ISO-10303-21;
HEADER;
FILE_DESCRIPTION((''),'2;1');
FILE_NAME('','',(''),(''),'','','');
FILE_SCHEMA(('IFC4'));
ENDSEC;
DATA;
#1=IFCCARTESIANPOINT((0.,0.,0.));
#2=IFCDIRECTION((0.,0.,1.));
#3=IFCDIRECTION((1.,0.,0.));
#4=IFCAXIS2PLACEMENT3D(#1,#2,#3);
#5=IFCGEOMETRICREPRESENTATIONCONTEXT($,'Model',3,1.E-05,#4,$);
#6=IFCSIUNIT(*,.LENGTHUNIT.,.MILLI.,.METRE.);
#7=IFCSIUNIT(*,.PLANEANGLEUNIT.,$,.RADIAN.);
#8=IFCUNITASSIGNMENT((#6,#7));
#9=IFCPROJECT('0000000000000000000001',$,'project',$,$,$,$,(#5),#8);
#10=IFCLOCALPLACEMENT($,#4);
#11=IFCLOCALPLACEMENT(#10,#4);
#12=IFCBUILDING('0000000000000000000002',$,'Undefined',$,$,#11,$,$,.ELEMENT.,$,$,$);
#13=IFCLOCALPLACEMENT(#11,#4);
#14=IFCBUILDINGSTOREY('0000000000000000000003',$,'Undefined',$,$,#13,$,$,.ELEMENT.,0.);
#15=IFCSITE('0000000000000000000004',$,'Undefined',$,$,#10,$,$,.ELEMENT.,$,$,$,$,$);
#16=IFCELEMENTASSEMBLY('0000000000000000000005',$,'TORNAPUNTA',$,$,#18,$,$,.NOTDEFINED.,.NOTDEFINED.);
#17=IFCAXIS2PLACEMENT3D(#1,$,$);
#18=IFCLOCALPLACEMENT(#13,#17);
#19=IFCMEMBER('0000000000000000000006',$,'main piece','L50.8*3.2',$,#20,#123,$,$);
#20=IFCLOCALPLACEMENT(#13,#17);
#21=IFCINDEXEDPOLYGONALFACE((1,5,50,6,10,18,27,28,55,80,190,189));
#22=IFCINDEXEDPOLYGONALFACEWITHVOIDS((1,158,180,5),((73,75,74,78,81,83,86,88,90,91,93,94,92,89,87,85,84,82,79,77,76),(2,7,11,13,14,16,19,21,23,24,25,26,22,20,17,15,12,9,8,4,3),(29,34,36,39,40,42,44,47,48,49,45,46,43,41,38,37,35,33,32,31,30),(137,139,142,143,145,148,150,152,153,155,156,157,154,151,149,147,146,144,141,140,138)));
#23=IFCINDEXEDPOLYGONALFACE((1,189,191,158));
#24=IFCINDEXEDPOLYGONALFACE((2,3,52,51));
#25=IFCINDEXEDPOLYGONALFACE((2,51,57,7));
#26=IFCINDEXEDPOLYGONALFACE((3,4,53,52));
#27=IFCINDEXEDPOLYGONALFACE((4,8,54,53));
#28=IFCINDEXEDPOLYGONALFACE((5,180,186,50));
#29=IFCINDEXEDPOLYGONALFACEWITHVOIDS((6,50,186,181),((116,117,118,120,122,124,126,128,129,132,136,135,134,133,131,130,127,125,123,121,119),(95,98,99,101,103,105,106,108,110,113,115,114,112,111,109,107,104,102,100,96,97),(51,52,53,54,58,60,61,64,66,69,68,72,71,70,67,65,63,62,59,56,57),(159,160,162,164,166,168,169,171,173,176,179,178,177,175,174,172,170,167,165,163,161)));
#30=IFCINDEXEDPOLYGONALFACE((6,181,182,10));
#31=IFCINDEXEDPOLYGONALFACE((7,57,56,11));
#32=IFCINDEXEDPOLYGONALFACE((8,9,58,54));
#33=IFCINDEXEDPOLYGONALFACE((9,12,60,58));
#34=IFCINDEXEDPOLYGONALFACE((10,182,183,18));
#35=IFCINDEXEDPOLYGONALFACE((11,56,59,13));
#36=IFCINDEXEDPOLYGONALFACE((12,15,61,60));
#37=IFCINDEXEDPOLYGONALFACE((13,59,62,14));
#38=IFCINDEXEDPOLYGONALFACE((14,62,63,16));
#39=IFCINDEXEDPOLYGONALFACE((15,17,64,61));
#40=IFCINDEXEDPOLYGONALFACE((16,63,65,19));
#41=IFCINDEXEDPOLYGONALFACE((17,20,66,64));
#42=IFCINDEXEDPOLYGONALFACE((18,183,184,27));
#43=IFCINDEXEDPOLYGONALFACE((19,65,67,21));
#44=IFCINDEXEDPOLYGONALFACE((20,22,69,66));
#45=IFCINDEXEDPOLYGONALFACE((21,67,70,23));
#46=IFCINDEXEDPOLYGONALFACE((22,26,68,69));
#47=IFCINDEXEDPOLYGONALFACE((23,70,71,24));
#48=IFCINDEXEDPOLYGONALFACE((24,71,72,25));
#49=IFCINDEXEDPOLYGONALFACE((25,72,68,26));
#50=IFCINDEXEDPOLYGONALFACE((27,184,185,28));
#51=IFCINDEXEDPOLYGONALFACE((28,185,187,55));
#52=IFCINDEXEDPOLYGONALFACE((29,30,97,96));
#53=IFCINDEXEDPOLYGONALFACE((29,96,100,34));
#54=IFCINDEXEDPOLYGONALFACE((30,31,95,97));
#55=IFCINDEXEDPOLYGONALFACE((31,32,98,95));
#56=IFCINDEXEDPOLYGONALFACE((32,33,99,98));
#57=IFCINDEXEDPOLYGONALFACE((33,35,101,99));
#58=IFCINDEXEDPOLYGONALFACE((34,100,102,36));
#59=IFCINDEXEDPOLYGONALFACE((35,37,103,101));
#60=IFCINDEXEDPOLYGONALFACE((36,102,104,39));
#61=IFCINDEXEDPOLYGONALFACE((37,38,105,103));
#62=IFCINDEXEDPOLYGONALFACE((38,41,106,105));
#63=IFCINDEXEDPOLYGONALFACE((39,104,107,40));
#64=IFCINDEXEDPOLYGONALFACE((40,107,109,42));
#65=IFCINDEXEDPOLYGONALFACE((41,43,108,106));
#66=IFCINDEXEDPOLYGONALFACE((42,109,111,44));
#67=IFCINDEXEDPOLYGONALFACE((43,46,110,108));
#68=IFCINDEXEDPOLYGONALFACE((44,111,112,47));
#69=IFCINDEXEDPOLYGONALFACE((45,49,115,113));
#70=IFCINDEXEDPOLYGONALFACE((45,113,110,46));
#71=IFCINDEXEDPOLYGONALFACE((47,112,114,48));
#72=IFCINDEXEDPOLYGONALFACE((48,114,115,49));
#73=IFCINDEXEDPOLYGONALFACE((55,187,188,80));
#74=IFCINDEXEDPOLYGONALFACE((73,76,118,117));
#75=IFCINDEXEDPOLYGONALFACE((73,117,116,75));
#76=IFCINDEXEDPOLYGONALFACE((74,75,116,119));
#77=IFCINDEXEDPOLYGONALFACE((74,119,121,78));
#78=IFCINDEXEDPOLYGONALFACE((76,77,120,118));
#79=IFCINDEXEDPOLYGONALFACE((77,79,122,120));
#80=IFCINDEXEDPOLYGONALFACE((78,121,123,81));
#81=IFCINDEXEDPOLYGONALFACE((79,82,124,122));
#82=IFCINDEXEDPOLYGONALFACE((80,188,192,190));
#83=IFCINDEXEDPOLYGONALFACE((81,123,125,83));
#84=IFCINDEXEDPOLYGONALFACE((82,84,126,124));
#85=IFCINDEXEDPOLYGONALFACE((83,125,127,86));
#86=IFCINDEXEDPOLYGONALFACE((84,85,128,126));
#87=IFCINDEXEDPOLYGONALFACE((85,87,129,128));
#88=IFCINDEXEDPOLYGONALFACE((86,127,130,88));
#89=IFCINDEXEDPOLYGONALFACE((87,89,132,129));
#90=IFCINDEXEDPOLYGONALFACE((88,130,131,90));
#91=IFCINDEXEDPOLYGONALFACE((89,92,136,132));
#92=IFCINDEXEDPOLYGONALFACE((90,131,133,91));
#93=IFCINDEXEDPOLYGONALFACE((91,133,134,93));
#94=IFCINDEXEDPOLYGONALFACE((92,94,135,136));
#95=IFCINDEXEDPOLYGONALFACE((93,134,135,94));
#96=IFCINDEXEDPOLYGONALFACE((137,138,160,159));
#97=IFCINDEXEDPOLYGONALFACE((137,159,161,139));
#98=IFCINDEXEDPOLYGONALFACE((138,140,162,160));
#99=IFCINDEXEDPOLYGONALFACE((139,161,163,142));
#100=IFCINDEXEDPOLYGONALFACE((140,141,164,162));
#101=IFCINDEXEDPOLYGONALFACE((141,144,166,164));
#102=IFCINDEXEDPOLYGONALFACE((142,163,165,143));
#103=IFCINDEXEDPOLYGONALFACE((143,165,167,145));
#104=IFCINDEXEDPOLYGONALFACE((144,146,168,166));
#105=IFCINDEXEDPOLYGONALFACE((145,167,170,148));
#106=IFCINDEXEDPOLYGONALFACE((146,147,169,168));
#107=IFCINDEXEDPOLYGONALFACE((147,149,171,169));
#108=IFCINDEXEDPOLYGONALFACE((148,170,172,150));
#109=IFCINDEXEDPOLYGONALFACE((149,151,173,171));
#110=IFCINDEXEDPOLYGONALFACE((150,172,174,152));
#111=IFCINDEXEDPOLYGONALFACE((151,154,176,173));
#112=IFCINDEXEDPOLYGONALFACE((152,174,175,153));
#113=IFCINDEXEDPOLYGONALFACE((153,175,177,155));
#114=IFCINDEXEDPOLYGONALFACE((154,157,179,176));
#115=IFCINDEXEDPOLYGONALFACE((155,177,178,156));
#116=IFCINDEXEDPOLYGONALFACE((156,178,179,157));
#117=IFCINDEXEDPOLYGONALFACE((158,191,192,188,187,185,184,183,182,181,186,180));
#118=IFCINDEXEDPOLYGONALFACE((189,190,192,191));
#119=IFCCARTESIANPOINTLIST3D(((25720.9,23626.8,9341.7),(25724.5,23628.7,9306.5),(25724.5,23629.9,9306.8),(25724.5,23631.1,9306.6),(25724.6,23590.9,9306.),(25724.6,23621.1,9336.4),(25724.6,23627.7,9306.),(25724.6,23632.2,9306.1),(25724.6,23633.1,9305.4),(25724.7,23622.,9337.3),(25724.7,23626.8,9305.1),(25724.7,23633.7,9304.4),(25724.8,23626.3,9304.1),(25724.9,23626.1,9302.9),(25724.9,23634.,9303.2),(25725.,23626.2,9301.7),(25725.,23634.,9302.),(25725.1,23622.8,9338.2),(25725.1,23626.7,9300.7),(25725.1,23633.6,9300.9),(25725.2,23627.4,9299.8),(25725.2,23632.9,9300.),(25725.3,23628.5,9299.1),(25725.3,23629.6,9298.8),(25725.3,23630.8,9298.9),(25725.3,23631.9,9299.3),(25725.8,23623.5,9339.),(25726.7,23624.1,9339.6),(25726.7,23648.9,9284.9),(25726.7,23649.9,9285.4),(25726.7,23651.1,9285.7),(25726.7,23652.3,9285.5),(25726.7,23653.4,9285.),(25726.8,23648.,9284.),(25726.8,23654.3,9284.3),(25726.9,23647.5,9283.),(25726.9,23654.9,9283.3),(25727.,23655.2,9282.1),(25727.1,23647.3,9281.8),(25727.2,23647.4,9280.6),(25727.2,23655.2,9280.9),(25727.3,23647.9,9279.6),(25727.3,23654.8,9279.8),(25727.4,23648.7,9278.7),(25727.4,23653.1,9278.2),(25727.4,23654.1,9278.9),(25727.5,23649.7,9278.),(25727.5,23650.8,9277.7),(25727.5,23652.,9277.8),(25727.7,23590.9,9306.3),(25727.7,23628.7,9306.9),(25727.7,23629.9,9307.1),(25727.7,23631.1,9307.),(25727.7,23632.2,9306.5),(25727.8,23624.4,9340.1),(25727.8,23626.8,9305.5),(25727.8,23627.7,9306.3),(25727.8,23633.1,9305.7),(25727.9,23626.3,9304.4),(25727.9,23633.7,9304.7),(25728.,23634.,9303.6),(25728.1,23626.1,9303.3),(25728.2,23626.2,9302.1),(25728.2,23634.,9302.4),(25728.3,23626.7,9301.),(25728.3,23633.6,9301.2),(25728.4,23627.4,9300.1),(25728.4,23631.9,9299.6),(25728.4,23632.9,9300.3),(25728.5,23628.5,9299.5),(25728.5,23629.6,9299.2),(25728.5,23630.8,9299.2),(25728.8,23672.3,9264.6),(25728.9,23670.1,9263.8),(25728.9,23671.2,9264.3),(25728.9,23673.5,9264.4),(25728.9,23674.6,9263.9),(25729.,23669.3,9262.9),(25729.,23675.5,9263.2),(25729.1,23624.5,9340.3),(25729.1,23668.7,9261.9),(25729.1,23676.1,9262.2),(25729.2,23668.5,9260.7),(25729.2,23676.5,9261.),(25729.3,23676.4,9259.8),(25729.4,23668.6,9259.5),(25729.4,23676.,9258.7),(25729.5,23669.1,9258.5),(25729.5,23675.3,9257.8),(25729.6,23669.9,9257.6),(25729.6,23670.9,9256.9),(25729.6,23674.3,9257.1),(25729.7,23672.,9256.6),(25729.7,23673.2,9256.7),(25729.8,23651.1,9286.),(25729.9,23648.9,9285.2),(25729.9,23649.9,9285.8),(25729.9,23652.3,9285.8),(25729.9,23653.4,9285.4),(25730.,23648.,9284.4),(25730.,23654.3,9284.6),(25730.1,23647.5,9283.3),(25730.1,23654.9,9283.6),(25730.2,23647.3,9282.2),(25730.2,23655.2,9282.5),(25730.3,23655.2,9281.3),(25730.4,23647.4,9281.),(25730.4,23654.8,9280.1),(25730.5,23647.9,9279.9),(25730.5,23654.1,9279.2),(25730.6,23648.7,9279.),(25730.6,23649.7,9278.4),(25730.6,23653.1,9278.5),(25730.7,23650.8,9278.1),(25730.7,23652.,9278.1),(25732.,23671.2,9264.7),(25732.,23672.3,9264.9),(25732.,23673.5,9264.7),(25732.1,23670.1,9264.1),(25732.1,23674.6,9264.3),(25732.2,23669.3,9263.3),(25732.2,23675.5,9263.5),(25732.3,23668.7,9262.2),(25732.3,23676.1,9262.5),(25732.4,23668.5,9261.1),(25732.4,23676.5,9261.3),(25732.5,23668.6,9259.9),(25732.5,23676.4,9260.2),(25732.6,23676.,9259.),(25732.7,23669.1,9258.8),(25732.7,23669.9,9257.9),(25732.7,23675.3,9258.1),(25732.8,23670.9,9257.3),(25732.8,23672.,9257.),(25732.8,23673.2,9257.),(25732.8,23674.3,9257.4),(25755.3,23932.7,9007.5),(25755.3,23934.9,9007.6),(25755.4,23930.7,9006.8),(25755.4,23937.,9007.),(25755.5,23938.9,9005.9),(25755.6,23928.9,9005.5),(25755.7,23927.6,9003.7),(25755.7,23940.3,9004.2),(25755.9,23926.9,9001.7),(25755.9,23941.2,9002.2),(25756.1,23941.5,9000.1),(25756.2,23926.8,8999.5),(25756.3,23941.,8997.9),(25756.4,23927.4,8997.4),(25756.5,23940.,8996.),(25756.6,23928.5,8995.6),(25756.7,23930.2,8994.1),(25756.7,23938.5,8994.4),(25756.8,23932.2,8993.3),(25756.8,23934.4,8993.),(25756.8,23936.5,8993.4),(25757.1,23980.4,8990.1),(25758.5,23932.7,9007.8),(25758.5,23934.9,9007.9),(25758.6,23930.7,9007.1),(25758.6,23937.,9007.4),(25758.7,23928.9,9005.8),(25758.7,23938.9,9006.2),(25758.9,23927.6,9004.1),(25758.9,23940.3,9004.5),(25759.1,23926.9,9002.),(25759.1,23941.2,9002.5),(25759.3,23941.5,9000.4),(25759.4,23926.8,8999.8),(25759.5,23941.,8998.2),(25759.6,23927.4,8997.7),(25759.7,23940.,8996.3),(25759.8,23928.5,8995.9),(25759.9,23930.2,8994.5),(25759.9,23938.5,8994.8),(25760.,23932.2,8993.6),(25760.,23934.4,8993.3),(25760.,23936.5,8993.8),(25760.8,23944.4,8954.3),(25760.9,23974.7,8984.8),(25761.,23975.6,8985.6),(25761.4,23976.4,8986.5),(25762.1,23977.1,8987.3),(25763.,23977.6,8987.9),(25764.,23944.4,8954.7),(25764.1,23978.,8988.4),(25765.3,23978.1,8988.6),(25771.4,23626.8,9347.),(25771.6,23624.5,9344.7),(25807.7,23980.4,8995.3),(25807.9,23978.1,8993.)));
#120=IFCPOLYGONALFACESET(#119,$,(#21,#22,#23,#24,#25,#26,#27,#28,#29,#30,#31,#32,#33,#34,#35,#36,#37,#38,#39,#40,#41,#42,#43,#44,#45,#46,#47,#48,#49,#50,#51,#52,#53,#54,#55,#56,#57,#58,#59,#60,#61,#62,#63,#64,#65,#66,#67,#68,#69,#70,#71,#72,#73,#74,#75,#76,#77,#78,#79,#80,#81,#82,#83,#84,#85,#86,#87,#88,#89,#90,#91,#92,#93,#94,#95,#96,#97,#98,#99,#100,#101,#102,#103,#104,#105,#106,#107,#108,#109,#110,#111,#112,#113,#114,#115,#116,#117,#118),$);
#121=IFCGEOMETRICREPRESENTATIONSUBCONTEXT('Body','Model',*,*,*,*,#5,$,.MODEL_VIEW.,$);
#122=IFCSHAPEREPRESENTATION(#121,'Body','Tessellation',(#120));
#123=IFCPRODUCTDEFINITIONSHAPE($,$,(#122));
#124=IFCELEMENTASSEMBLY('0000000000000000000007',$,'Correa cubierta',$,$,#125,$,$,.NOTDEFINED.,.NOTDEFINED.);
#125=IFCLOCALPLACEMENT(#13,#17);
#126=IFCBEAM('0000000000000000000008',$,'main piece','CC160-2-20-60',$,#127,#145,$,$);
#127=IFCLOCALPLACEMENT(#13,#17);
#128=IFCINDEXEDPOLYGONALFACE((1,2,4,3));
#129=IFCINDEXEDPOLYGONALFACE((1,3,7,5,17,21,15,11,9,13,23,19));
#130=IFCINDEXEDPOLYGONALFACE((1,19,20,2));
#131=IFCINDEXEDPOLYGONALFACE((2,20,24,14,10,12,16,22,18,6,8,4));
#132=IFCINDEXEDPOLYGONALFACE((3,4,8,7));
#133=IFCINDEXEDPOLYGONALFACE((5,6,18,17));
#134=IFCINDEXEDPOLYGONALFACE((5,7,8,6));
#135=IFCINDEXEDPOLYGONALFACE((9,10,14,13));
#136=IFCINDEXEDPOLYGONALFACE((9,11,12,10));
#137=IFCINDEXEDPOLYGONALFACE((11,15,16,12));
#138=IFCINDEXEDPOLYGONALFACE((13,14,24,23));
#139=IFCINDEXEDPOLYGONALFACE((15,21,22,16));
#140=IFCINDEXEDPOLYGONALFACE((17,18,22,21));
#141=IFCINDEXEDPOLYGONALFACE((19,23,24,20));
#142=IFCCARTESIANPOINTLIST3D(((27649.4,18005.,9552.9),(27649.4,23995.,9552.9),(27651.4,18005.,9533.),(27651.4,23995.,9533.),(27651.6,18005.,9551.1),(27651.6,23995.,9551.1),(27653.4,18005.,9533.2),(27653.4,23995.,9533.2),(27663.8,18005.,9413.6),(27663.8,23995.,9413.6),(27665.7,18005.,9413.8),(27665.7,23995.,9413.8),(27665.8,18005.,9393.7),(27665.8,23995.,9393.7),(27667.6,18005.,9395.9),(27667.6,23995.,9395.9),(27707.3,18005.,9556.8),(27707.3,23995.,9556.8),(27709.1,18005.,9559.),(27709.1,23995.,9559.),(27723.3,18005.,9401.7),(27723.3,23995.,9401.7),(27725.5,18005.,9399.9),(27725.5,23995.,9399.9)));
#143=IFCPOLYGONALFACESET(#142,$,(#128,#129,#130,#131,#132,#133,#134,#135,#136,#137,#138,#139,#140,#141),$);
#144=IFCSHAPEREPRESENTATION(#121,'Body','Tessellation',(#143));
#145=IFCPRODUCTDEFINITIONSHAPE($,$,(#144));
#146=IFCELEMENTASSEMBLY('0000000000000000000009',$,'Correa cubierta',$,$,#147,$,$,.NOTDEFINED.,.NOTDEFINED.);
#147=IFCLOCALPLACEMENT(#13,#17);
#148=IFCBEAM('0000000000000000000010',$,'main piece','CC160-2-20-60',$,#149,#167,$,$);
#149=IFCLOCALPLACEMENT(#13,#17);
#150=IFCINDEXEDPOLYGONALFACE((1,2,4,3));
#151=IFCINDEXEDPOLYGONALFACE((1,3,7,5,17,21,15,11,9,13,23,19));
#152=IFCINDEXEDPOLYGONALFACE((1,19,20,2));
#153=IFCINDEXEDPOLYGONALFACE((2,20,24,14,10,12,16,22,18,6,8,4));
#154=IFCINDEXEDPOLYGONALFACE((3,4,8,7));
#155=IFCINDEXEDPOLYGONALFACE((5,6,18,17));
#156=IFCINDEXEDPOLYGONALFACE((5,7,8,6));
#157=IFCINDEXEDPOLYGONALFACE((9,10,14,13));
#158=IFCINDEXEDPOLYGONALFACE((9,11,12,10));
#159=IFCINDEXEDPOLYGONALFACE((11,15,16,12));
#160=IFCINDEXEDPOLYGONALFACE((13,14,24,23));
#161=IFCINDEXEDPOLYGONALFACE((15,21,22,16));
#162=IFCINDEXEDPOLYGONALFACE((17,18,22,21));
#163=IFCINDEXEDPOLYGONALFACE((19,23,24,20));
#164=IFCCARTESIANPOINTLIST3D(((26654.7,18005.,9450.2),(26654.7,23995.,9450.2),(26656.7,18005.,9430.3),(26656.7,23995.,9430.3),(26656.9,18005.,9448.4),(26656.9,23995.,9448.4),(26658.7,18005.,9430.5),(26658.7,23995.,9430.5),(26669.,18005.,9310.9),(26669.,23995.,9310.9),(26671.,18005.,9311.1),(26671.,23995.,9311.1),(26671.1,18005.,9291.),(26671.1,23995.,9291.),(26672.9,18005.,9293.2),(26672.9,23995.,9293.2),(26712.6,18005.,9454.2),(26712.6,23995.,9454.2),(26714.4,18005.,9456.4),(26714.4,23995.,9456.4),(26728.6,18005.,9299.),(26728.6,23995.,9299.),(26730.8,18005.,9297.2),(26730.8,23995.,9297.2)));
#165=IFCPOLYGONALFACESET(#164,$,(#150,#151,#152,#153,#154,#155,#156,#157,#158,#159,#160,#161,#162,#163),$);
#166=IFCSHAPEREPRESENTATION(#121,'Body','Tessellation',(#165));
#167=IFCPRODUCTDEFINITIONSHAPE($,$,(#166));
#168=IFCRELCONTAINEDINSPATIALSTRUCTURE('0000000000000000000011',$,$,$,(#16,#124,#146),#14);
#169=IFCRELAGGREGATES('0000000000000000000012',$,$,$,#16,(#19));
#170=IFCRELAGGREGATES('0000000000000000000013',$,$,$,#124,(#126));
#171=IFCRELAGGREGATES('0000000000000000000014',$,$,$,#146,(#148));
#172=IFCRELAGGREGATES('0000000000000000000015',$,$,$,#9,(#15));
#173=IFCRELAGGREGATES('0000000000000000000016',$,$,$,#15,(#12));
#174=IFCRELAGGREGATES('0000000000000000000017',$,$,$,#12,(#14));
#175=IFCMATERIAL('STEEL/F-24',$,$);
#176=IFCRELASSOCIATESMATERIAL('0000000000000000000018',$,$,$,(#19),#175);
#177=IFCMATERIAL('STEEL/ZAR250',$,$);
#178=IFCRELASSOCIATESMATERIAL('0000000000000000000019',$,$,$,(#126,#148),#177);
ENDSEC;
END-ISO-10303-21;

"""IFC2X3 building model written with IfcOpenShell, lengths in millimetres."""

from ifc_helpers import new_model, si_unit, frame, origin_with_axes, origin_2d_with_axis, place, context, subcontext, project, spatial, circle, l_section, c_section, extrude, source, transform, mapped, material, element, aggregate, save


model = new_model("IFC2X3")

# Units and contexts
model_context = context("Model", 3, precision=1e-05, world=origin_with_axes())
body_context = subcontext(model_context, "Body", "Model", "MODEL_VIEW")
ifc_project = project(units=[si_unit("LENGTHUNIT", "METRE", prefix="MILLI"), si_unit("PLANEANGLEUNIT", "RADIAN")], contexts=[model_context])

# Site, building, storey
site_placement = place(None, origin_with_axes())
site = spatial("IfcSite", under=ifc_project, at=site_placement, Name="Undefined", CompositionType="ELEMENT")
building_placement = place(site_placement, origin_with_axes())
building = spatial("IfcBuilding", under=site, at=building_placement, Name="Undefined", CompositionType="ELEMENT")
storey_placement = place(building_placement, origin_with_axes())
storey = spatial("IfcBuildingStorey", under=building, at=storey_placement, Name="Undefined", CompositionType="ELEMENT", Elevation=0.0)

# Element assembly, member, openings
ifc_material_1 = material(Name="STEEL/F-24")
shared_shape_1 = source(origin_with_axes(), body_context, "Body", "SweptSolid", [
    extrude(circle(Radius=4.0, at=origin_2d_with_axis()), frame((0.0, -3.3, 0.0), z_axis=(0.0, 1.0, 0.0), x_axis=(1.0, 0.0, 0.0)), (0.0, 0.0, 1.0), 3.4),
])
shared_shape_2 = source(origin_with_axes(), body_context, "Body", "SweptSolid", [
    extrude(circle(Radius=7.3, at=origin_2d_with_axis()), frame((0.0, -3.3, 0.0), z_axis=(0.0, 1.0, 0.0), x_axis=(1.0, 0.0, 0.0)), (0.0, 0.0, 1.0), 3.4),
])
assembly_1_placement = place(storey_placement, origin_with_axes())
assembly_1 = element("IfcElementAssembly", 1, at=assembly_1_placement, inside=storey, Name="TORNAPUNTA", AssemblyPlace="NOTDEFINED", PredefinedType="NOTDEFINED")
member_1_placement = place(assembly_1_placement, frame((25748.0, 23608.8, 9326.5), z_axis=(0.994727, 0.0, 0.102562), x_axis=(0.072522, 0.707107, -0.703378)))
member_1 = element("IfcMember", 2, at=member_1_placement, material=ifc_material_1, Name="main piece", Description="L50.8*3.2", context=body_context, shape_type="SweptSolid", body=[
    extrude(l_section(Depth=50.8, Width=50.8, Thickness=3.2, FilletRadius=4.8, at=origin_2d_with_axis()), frame((500.0, 0.0, 0.0), z_axis=(-1.0, 0.0, 0.0), x_axis=(0.0, -1.0, 0.0)), (0.0, 0.0, 1.0), 500.0),
])
opening_1_placement = place(assembly_1_placement, frame((25724.9, 23630.1, 9302.8), z_axis=(-0.072522, 0.707107, 0.703378), x_axis=(0.072522, 0.707107, -0.703378)))
element("IfcOpeningElement", 3, at=opening_1_placement, cuts=member_1, ObjectType="Opening", context=body_context, shape_type="MappedRepresentation", body=[
    mapped(shared_shape_1, transform((0.0, 0.0, 0.0))),
    mapped(shared_shape_1, transform((30.0, 0.0, 0.0))),
    mapped(shared_shape_1, transform((60.0, 0.0, 0.0))),
])
opening_2_placement = place(assembly_1_placement, frame((25756.1, 23934.1, 9000.3), z_axis=(0.072522, -0.707107, -0.703378), x_axis=(-0.072522, -0.707107, 0.703378)))
element("IfcOpeningElement", 4, at=opening_2_placement, cuts=member_1, ObjectType="Opening", context=body_context, shape_type="MappedRepresentation", body=[
    mapped(shared_shape_2, transform((0.0, 0.0, 0.0))),
])
aggregate(assembly_1, [member_1])

# Element assemblies, beams
assembly_2_placement = place(storey_placement, origin_with_axes())
assembly_2 = element("IfcElementAssembly", 5, at=assembly_2_placement, inside=storey, Name="Correa cubierta", AssemblyPlace="NOTDEFINED", PredefinedType="NOTDEFINED")
ifc_material_2 = material(Name="STEEL/ZAR250")
beam_1_placement = place(assembly_2_placement, frame((27687.4, 23995.0, 9476.4), z_axis=(-0.102562, 0.0, 0.994727), x_axis=(0.0, -1.0, 0.0)))
beam_1 = element("IfcBeam", 6, at=beam_1_placement, material=ifc_material_2, Name="main piece", Description="CC160-2-20-60", context=body_context, shape_type="SweptSolid", body=[
    extrude(c_section(Depth=160.0, Width=60.0, WallThickness=2.0, Girth=20.0, at=origin_2d_with_axis()), frame((5990.0, 0.0, 0.0), z_axis=(-1.0, 0.0, 0.0), x_axis=(0.0, -1.0, 0.0)), (0.0, 0.0, 1.0), 5990.0),
])
aggregate(assembly_2, [beam_1])
assembly_3_placement = place(storey_placement, origin_with_axes())
assembly_3 = element("IfcElementAssembly", 7, at=assembly_3_placement, inside=storey, Name="Correa cubierta", AssemblyPlace="NOTDEFINED", PredefinedType="NOTDEFINED")
beam_2_placement = place(assembly_3_placement, frame((26692.7, 23995.0, 9373.7), z_axis=(-0.102562, 0.0, 0.994727), x_axis=(0.0, -1.0, 0.0)))
beam_2 = element("IfcBeam", 8, at=beam_2_placement, material=ifc_material_2, Name="main piece", Description="CC160-2-20-60", context=body_context, shape_type="SweptSolid", body=[
    extrude(c_section(Depth=160.0, Width=60.0, WallThickness=2.0, Girth=20.0, at=origin_2d_with_axis()), frame((5990.0, 0.0, 0.0), z_axis=(-1.0, 0.0, 0.0), x_axis=(0.0, -1.0, 0.0)), (0.0, 0.0, 1.0), 5990.0),
])
aggregate(assembly_3, [beam_2])

save(model, "model.ifc")
